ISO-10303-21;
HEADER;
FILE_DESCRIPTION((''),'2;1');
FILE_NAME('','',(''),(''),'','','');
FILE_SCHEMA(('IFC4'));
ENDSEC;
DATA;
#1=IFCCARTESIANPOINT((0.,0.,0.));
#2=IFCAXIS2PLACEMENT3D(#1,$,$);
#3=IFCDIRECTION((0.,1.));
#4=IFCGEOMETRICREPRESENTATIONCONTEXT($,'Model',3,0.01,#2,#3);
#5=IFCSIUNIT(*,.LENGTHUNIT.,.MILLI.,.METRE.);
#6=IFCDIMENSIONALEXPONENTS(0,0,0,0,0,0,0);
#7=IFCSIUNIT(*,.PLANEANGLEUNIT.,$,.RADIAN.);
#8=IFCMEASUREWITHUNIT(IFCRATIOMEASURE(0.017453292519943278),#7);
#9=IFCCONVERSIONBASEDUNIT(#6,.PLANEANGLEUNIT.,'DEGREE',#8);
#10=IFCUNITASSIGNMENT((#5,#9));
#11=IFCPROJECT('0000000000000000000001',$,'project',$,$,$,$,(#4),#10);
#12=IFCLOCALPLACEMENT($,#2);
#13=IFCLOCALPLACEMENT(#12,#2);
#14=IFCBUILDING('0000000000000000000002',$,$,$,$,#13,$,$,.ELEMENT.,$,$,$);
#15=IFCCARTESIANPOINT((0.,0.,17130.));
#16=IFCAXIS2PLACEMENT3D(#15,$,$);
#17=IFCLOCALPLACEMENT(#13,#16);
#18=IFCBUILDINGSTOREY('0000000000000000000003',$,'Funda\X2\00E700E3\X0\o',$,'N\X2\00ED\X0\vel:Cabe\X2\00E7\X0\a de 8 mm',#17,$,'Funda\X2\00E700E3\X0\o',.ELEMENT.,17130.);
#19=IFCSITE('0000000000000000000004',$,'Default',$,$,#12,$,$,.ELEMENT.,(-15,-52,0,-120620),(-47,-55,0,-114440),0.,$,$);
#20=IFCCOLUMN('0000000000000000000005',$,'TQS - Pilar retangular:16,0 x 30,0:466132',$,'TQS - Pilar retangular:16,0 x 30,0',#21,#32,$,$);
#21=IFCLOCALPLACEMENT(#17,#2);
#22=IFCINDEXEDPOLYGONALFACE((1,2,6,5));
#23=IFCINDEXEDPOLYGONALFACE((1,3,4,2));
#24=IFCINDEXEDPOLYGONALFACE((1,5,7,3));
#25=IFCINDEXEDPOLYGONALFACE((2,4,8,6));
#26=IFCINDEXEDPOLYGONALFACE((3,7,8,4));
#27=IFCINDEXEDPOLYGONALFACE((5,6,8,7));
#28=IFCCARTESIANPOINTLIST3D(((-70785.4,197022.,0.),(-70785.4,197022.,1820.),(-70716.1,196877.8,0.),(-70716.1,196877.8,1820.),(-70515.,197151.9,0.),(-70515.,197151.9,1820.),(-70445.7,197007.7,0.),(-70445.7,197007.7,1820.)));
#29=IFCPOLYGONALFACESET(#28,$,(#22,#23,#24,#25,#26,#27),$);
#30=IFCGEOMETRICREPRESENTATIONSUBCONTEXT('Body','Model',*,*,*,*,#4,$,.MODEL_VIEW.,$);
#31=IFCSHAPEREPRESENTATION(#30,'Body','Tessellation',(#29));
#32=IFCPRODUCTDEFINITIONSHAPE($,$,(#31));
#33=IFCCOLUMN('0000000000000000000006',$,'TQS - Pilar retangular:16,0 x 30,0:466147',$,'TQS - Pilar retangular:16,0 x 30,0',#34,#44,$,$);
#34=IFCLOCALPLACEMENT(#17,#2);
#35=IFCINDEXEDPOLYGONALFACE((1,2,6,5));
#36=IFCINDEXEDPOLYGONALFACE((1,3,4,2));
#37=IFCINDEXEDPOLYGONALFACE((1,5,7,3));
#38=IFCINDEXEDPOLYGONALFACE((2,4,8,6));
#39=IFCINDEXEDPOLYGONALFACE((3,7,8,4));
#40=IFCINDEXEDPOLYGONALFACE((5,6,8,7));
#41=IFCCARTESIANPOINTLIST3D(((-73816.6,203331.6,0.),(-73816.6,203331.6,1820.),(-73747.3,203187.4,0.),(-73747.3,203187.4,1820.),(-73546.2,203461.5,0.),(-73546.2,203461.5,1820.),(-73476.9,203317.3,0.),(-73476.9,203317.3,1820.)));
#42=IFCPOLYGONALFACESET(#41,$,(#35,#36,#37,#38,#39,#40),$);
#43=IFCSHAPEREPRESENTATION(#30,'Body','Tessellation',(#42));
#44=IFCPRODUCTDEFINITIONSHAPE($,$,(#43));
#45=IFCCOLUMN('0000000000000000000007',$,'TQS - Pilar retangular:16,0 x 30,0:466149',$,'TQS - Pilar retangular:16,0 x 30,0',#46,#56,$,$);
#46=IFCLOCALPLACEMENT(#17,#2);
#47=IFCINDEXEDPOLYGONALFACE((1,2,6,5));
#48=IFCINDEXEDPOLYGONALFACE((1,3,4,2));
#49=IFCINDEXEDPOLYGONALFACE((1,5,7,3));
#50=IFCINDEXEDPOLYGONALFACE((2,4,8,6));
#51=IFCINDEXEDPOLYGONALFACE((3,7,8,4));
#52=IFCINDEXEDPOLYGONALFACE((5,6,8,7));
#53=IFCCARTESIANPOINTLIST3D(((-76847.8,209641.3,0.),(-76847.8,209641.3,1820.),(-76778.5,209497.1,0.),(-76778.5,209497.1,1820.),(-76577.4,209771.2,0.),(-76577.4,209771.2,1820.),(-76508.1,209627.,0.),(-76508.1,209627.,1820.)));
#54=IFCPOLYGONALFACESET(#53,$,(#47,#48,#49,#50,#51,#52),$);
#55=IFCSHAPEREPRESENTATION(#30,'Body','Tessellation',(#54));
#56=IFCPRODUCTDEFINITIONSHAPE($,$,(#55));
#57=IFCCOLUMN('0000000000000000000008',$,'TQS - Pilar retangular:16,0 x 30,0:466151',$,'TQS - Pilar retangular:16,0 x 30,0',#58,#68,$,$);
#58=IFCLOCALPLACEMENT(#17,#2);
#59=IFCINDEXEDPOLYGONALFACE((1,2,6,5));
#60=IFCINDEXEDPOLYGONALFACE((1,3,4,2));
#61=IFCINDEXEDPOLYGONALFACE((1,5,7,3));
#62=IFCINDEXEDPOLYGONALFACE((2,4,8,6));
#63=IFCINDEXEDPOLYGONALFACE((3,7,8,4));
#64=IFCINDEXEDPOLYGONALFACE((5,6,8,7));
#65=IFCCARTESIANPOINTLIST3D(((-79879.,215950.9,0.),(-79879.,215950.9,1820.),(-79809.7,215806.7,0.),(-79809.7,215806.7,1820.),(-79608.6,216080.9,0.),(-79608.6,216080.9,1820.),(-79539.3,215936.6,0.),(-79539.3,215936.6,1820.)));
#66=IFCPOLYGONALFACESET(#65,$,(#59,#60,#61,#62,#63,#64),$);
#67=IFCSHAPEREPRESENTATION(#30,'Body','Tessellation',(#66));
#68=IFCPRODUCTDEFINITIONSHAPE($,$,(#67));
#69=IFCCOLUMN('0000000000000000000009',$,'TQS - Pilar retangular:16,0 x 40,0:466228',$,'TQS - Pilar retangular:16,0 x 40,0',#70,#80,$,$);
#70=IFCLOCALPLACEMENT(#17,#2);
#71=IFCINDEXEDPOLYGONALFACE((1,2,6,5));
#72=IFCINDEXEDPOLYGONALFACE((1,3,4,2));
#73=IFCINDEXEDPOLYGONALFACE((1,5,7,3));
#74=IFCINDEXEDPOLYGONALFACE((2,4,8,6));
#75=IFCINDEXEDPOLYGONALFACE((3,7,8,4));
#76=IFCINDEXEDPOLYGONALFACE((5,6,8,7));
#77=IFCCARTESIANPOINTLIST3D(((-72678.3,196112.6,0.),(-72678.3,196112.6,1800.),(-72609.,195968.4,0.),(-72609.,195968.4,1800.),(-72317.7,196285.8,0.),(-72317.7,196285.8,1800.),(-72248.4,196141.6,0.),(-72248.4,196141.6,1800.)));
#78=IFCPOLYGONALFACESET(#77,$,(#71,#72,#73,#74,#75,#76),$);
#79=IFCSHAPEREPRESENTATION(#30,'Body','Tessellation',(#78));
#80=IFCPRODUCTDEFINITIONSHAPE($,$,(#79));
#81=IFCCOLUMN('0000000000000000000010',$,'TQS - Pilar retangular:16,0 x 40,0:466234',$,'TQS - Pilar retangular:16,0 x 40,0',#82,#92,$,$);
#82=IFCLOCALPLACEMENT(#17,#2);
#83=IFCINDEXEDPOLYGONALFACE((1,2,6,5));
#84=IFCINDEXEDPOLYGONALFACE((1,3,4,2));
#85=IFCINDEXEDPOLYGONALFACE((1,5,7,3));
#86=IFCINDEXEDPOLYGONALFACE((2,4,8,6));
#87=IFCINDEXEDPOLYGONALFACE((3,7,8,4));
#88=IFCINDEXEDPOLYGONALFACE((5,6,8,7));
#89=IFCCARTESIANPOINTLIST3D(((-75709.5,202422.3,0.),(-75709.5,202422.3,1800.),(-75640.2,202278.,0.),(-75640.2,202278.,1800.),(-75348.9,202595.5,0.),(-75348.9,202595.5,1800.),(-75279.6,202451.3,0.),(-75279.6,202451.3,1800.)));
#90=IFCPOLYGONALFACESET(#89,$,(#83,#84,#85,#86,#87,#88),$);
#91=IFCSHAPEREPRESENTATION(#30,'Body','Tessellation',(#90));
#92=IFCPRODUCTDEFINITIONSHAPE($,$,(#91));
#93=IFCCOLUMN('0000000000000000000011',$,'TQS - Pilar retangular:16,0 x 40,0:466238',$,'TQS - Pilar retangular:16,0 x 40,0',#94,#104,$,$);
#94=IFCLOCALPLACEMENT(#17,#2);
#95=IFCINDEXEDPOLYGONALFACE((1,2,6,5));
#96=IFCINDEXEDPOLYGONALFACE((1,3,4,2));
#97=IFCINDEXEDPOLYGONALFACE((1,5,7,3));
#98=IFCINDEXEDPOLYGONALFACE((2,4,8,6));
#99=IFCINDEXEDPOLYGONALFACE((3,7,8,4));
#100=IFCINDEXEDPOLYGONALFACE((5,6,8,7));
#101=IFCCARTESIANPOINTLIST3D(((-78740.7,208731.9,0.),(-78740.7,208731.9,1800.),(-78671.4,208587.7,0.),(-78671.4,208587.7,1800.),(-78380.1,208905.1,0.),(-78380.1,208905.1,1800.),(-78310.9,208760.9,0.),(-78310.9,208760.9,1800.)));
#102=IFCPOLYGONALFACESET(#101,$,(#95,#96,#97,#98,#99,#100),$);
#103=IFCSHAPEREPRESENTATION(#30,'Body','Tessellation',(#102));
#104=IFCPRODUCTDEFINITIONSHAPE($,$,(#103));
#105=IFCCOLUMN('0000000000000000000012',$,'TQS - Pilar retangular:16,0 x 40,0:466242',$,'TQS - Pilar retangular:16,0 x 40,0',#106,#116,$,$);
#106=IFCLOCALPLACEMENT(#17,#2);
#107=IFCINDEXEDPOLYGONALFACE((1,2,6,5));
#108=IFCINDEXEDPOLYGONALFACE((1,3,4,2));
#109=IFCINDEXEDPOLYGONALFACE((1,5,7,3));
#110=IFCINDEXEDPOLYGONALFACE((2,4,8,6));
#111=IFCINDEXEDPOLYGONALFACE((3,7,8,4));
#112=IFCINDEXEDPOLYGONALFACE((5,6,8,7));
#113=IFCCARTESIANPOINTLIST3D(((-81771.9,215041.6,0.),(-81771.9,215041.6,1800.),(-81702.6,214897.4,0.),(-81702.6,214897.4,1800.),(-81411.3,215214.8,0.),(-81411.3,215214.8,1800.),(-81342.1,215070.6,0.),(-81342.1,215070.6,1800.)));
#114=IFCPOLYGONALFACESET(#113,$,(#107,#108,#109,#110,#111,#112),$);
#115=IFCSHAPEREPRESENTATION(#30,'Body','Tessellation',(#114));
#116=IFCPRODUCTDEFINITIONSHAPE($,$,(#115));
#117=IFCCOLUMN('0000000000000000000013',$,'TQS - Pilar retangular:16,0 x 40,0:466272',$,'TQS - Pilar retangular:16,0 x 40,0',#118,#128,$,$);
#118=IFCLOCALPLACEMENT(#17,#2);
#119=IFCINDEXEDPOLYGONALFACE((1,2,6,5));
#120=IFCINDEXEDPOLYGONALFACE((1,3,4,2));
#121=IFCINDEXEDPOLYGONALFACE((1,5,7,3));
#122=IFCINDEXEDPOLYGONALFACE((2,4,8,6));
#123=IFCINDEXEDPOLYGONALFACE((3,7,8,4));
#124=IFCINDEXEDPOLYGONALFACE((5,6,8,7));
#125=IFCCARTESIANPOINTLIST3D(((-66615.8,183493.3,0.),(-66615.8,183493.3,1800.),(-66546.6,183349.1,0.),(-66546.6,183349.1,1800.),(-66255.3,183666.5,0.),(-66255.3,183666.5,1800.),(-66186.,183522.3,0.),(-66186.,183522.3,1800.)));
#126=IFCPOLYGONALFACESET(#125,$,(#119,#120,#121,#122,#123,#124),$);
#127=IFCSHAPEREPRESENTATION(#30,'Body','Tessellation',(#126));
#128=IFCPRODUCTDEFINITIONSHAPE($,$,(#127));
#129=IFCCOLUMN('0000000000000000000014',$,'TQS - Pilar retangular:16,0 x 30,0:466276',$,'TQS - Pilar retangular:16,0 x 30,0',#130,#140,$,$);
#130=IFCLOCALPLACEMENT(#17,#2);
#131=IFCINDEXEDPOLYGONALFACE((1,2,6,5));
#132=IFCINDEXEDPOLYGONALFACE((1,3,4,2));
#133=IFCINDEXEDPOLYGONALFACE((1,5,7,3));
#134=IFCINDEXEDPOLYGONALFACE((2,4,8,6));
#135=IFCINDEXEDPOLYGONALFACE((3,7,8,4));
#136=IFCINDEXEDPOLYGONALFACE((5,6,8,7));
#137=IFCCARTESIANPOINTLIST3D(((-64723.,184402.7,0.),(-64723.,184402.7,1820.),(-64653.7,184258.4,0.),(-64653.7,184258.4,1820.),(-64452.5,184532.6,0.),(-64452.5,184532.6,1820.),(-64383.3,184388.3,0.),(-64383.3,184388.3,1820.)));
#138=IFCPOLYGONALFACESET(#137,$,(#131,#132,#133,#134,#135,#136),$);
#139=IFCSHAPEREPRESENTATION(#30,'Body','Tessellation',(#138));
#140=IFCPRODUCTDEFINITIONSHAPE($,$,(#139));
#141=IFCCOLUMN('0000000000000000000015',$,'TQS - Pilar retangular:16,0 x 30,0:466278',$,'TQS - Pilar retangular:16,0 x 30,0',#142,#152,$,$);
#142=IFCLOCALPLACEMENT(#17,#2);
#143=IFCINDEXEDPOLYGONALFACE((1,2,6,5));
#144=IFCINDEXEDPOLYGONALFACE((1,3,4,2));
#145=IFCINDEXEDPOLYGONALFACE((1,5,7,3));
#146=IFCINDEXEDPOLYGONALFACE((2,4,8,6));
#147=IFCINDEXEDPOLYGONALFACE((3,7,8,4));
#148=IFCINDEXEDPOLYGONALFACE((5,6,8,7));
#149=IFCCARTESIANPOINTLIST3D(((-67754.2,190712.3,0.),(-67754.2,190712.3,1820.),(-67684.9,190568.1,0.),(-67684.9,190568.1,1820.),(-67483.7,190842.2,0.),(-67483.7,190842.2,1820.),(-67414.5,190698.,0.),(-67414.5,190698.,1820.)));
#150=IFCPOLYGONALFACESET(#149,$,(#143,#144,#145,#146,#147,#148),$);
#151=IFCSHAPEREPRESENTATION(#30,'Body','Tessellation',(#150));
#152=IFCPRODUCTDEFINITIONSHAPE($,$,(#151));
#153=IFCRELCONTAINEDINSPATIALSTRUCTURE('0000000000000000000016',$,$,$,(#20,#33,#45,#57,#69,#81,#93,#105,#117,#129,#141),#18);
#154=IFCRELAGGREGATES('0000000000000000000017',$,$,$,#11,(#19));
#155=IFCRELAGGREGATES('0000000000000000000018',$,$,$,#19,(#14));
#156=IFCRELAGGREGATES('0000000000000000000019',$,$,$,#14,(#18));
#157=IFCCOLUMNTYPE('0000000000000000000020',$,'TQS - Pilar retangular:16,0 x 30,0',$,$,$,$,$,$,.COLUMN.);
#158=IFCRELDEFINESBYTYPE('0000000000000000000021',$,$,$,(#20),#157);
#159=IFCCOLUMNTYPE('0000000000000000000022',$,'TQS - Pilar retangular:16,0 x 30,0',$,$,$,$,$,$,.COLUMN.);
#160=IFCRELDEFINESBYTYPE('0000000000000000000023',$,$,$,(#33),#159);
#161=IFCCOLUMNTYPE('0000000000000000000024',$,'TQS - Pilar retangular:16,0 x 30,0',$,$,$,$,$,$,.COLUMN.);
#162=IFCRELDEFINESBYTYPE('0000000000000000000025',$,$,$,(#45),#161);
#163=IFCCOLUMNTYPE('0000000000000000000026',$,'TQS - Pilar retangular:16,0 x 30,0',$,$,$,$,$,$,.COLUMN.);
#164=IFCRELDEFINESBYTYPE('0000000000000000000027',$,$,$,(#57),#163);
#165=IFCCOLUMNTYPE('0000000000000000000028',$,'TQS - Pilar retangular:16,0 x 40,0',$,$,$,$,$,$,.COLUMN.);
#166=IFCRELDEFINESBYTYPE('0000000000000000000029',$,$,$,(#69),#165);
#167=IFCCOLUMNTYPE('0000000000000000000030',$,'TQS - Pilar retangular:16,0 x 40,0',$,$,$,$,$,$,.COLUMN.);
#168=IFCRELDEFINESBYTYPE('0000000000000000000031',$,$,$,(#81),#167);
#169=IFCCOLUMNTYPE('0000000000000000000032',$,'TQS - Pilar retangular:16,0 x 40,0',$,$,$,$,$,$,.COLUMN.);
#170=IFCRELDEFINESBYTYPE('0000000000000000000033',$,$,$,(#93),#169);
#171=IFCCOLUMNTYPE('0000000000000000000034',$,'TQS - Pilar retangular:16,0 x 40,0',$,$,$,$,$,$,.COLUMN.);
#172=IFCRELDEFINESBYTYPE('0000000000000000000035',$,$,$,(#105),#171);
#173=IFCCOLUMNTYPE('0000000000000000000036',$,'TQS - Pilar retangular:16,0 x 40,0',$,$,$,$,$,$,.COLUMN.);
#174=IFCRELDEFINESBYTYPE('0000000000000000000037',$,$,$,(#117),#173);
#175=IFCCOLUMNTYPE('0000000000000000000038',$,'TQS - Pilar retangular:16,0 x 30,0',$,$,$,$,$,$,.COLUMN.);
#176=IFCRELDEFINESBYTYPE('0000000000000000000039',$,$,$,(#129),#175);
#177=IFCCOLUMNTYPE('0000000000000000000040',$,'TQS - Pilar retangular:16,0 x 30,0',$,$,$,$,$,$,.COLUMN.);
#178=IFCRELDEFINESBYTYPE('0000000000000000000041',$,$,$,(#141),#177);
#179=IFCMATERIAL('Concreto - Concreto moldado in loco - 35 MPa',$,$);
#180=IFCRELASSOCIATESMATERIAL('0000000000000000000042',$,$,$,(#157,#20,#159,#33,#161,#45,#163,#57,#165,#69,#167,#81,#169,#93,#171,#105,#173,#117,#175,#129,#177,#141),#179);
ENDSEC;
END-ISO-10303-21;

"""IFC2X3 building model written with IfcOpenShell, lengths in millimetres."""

from ifc_helpers import new_model, entity, si_unit, converted_unit, direction, frame, origin, origin_2d_with_axis, place, context, subcontext, project, spatial, rectangle, extrude, source, transform, mapped, material, type_object, type_shapes, element, save


model = new_model("IFC2X3")

# Units and contexts
model_context = context("Model", 3, precision=0.01, world=origin(), true_north=direction((0.0, 1.0)))
body_context = subcontext(model_context, "Body", "Model", "MODEL_VIEW")
ifc_project = project(units=[si_unit("LENGTHUNIT", "METRE", prefix="MILLI"), converted_unit("PLANEANGLEUNIT", "DEGREE", entity("IfcRatioMeasure", 0.017453292519943278), si_unit("PLANEANGLEUNIT", "RADIAN"), dimensions=[0, 0, 0, 0, 0, 0, 0])], contexts=[model_context])

# Site, building, storey
site_placement = place(None, origin())
site = spatial("IfcSite", under=ifc_project, at=site_placement, Name="Default", CompositionType="ELEMENT", RefLatitude=(-15, -52, 0, -120620), RefLongitude=(-47, -55, 0, -114440), RefElevation=0.0)
building_placement = place(site_placement, origin())
building = spatial("IfcBuilding", under=site, at=building_placement, CompositionType="ELEMENT")
storey_placement = place(building_placement, frame((0.0, 0.0, 17130.0)))
storey = spatial("IfcBuildingStorey", under=building, at=storey_placement, Name="Fundação", ObjectType="Nível:Cabeça de 8 mm", LongName="Fundação", CompositionType="ELEMENT", Elevation=17130.0)

# Columns
ifc_material_1 = material(Name="Concreto - Concreto moldado in loco - 35 MPa")
column_type_1 = type_object("IfcColumnType", Name="TQS - Pilar retangular:16,0 x 30,0", PredefinedType="COLUMN", material=ifc_material_1)
shared_shape_1 = source(origin(), body_context, "Body", "SweptSolid", [
    extrude(rectangle(XDim=300.0, YDim=160.0, at=origin_2d_with_axis()), frame((-70615.5, 197014.8, 17130.0), z_axis=(0.0, 0.0, 1.0), x_axis=(-0.90138, -0.43303, 0.0)), (0.0, 0.0, 1.0), 1820.0),
])
type_shapes(column_type_1, [shared_shape_1])
column_1_placement = place(storey_placement, frame((0.0, 0.0, -17130.0)))
element("IfcColumn", 1, at=column_1_placement, inside=storey, type_object=column_type_1, material=ifc_material_1, Name="TQS - Pilar retangular:16,0 x 30,0:466132", ObjectType="TQS - Pilar retangular:16,0 x 30,0", context=body_context, shape_type="MappedRepresentation", body=[
    mapped(shared_shape_1, transform((0.0, 0.0, 0.0), scale=1.0)),
])
column_type_2 = type_object("IfcColumnType", Name="TQS - Pilar retangular:16,0 x 30,0", PredefinedType="COLUMN", material=ifc_material_1)
shared_shape_2 = source(origin(), body_context, "Body", "SweptSolid", [
    extrude(rectangle(XDim=300.0, YDim=160.0, at=origin_2d_with_axis()), frame((-73646.7, 203324.5, 17130.0), z_axis=(0.0, 0.0, 1.0), x_axis=(-0.90138, -0.43303, 0.0)), (0.0, 0.0, 1.0), 1820.0),
])
type_shapes(column_type_2, [shared_shape_2])
column_2_placement = place(storey_placement, frame((0.0, 0.0, -17130.0)))
element("IfcColumn", 2, at=column_2_placement, inside=storey, type_object=column_type_2, material=ifc_material_1, Name="TQS - Pilar retangular:16,0 x 30,0:466147", ObjectType="TQS - Pilar retangular:16,0 x 30,0", context=body_context, shape_type="MappedRepresentation", body=[
    mapped(shared_shape_2, transform((0.0, 0.0, 0.0), scale=1.0)),
])
column_type_3 = type_object("IfcColumnType", Name="TQS - Pilar retangular:16,0 x 30,0", PredefinedType="COLUMN", material=ifc_material_1)
shared_shape_3 = source(origin(), body_context, "Body", "SweptSolid", [
    extrude(rectangle(XDim=300.0, YDim=160.0, at=origin_2d_with_axis()), frame((-76677.9, 209634.1, 17130.0), z_axis=(0.0, 0.0, 1.0), x_axis=(-0.90138, -0.43303, 0.0)), (0.0, 0.0, 1.0), 1820.0),
])
type_shapes(column_type_3, [shared_shape_3])
column_3_placement = place(storey_placement, frame((0.0, 0.0, -17130.0)))
element("IfcColumn", 3, at=column_3_placement, inside=storey, type_object=column_type_3, material=ifc_material_1, Name="TQS - Pilar retangular:16,0 x 30,0:466149", ObjectType="TQS - Pilar retangular:16,0 x 30,0", context=body_context, shape_type="MappedRepresentation", body=[
    mapped(shared_shape_3, transform((0.0, 0.0, 0.0), scale=1.0)),
])
column_type_4 = type_object("IfcColumnType", Name="TQS - Pilar retangular:16,0 x 30,0", PredefinedType="COLUMN", material=ifc_material_1)
shared_shape_4 = source(origin(), body_context, "Body", "SweptSolid", [
    extrude(rectangle(XDim=300.0, YDim=160.0, at=origin_2d_with_axis()), frame((-79709.2, 215943.8, 17130.0), z_axis=(0.0, 0.0, 1.0), x_axis=(-0.90138, -0.43303, 0.0)), (0.0, 0.0, 1.0), 1820.0),
])
type_shapes(column_type_4, [shared_shape_4])
column_4_placement = place(storey_placement, frame((0.0, 0.0, -17130.0)))
element("IfcColumn", 4, at=column_4_placement, inside=storey, type_object=column_type_4, material=ifc_material_1, Name="TQS - Pilar retangular:16,0 x 30,0:466151", ObjectType="TQS - Pilar retangular:16,0 x 30,0", context=body_context, shape_type="MappedRepresentation", body=[
    mapped(shared_shape_4, transform((0.0, 0.0, 0.0), scale=1.0)),
])
column_type_5 = type_object("IfcColumnType", Name="TQS - Pilar retangular:16,0 x 40,0", PredefinedType="COLUMN", material=ifc_material_1)
shared_shape_5 = source(origin(), body_context, "Body", "SweptSolid", [
    extrude(rectangle(XDim=400.0, YDim=160.0, at=origin_2d_with_axis()), frame((-72463.4, 196127.1, 17130.0), z_axis=(0.0, 0.0, 1.0), x_axis=(-0.90138, -0.43303, 0.0)), (0.0, 0.0, 1.0), 1800.0),
])
type_shapes(column_type_5, [shared_shape_5])
column_5_placement = place(storey_placement, frame((0.0, 0.0, -17130.0)))
element("IfcColumn", 5, at=column_5_placement, inside=storey, type_object=column_type_5, material=ifc_material_1, Name="TQS - Pilar retangular:16,0 x 40,0:466228", ObjectType="TQS - Pilar retangular:16,0 x 40,0", context=body_context, shape_type="MappedRepresentation", body=[
    mapped(shared_shape_5, transform((0.0, 0.0, 0.0), scale=1.0)),
])
column_type_6 = type_object("IfcColumnType", Name="TQS - Pilar retangular:16,0 x 40,0", PredefinedType="COLUMN", material=ifc_material_1)
shared_shape_6 = source(origin(), body_context, "Body", "SweptSolid", [
    extrude(rectangle(XDim=400.0, YDim=160.0, at=origin_2d_with_axis()), frame((-75494.6, 202436.8, 17130.0), z_axis=(0.0, 0.0, 1.0), x_axis=(-0.90138, -0.43303, 0.0)), (0.0, 0.0, 1.0), 1800.0),
])
type_shapes(column_type_6, [shared_shape_6])
column_6_placement = place(storey_placement, frame((0.0, 0.0, -17130.0)))
element("IfcColumn", 6, at=column_6_placement, inside=storey, type_object=column_type_6, material=ifc_material_1, Name="TQS - Pilar retangular:16,0 x 40,0:466234", ObjectType="TQS - Pilar retangular:16,0 x 40,0", context=body_context, shape_type="MappedRepresentation", body=[
    mapped(shared_shape_6, transform((0.0, 0.0, 0.0), scale=1.0)),
])
column_type_7 = type_object("IfcColumnType", Name="TQS - Pilar retangular:16,0 x 40,0", PredefinedType="COLUMN", material=ifc_material_1)
shared_shape_7 = source(origin(), body_context, "Body", "SweptSolid", [
    extrude(rectangle(XDim=400.0, YDim=160.0, at=origin_2d_with_axis()), frame((-78525.8, 208746.4, 17130.0), z_axis=(0.0, 0.0, 1.0), x_axis=(-0.90138, -0.43303, 0.0)), (0.0, 0.0, 1.0), 1800.0),
])
type_shapes(column_type_7, [shared_shape_7])
column_7_placement = place(storey_placement, frame((0.0, 0.0, -17130.0)))
element("IfcColumn", 7, at=column_7_placement, inside=storey, type_object=column_type_7, material=ifc_material_1, Name="TQS - Pilar retangular:16,0 x 40,0:466238", ObjectType="TQS - Pilar retangular:16,0 x 40,0", context=body_context, shape_type="MappedRepresentation", body=[
    mapped(shared_shape_7, transform((0.0, 0.0, 0.0), scale=1.0)),
])
column_type_8 = type_object("IfcColumnType", Name="TQS - Pilar retangular:16,0 x 40,0", PredefinedType="COLUMN", material=ifc_material_1)
shared_shape_8 = source(origin(), body_context, "Body", "SweptSolid", [
    extrude(rectangle(XDim=400.0, YDim=160.0, at=origin_2d_with_axis()), frame((-81557.0, 215056.1, 17130.0), z_axis=(0.0, 0.0, 1.0), x_axis=(-0.90138, -0.43303, 0.0)), (0.0, 0.0, 1.0), 1800.0),
])
type_shapes(column_type_8, [shared_shape_8])
column_8_placement = place(storey_placement, frame((0.0, 0.0, -17130.0)))
element("IfcColumn", 8, at=column_8_placement, inside=storey, type_object=column_type_8, material=ifc_material_1, Name="TQS - Pilar retangular:16,0 x 40,0:466242", ObjectType="TQS - Pilar retangular:16,0 x 40,0", context=body_context, shape_type="MappedRepresentation", body=[
    mapped(shared_shape_8, transform((0.0, 0.0, 0.0), scale=1.0)),
])
column_type_9 = type_object("IfcColumnType", Name="TQS - Pilar retangular:16,0 x 40,0", PredefinedType="COLUMN", material=ifc_material_1)
shared_shape_9 = source(origin(), body_context, "Body", "SweptSolid", [
    extrude(rectangle(XDim=400.0, YDim=160.0, at=origin_2d_with_axis()), frame((-66400.9, 183507.8, 17130.0), z_axis=(0.0, 0.0, 1.0), x_axis=(-0.90138, -0.43303, 0.0)), (0.0, 0.0, 1.0), 1800.0),
])
type_shapes(column_type_9, [shared_shape_9])
column_9_placement = place(storey_placement, frame((0.0, 0.0, -17130.0)))
element("IfcColumn", 9, at=column_9_placement, inside=storey, type_object=column_type_9, material=ifc_material_1, Name="TQS - Pilar retangular:16,0 x 40,0:466272", ObjectType="TQS - Pilar retangular:16,0 x 40,0", context=body_context, shape_type="MappedRepresentation", body=[
    mapped(shared_shape_9, transform((0.0, 0.0, 0.0), scale=1.0)),
])
column_type_10 = type_object("IfcColumnType", Name="TQS - Pilar retangular:16,0 x 30,0", PredefinedType="COLUMN", material=ifc_material_1)
shared_shape_10 = source(origin(), body_context, "Body", "SweptSolid", [
    extrude(rectangle(XDim=300.0, YDim=160.0, at=origin_2d_with_axis()), frame((-64553.1, 184395.5, 17130.0), z_axis=(0.0, 0.0, 1.0), x_axis=(-0.90138, -0.43303, 0.0)), (0.0, 0.0, 1.0), 1820.0),
])
type_shapes(column_type_10, [shared_shape_10])
column_10_placement = place(storey_placement, frame((0.0, 0.0, -17130.0)))
element("IfcColumn", 10, at=column_10_placement, inside=storey, type_object=column_type_10, material=ifc_material_1, Name="TQS - Pilar retangular:16,0 x 30,0:466276", ObjectType="TQS - Pilar retangular:16,0 x 30,0", context=body_context, shape_type="MappedRepresentation", body=[
    mapped(shared_shape_10, transform((0.0, 0.0, 0.0), scale=1.0)),
])
column_type_11 = type_object("IfcColumnType", Name="TQS - Pilar retangular:16,0 x 30,0", PredefinedType="COLUMN", material=ifc_material_1)
shared_shape_11 = source(origin(), body_context, "Body", "SweptSolid", [
    extrude(rectangle(XDim=300.0, YDim=160.0, at=origin_2d_with_axis()), frame((-67584.3, 190705.2, 17130.0), z_axis=(0.0, 0.0, 1.0), x_axis=(-0.90138, -0.43303, 0.0)), (0.0, 0.0, 1.0), 1820.0),
])
type_shapes(column_type_11, [shared_shape_11])
column_11_placement = place(storey_placement, frame((0.0, 0.0, -17130.0)))
element("IfcColumn", 11, at=column_11_placement, inside=storey, type_object=column_type_11, material=ifc_material_1, Name="TQS - Pilar retangular:16,0 x 30,0:466278", ObjectType="TQS - Pilar retangular:16,0 x 30,0", context=body_context, shape_type="MappedRepresentation", body=[
    mapped(shared_shape_11, transform((0.0, 0.0, 0.0), scale=1.0)),
])

save(model, "model.ifc")
